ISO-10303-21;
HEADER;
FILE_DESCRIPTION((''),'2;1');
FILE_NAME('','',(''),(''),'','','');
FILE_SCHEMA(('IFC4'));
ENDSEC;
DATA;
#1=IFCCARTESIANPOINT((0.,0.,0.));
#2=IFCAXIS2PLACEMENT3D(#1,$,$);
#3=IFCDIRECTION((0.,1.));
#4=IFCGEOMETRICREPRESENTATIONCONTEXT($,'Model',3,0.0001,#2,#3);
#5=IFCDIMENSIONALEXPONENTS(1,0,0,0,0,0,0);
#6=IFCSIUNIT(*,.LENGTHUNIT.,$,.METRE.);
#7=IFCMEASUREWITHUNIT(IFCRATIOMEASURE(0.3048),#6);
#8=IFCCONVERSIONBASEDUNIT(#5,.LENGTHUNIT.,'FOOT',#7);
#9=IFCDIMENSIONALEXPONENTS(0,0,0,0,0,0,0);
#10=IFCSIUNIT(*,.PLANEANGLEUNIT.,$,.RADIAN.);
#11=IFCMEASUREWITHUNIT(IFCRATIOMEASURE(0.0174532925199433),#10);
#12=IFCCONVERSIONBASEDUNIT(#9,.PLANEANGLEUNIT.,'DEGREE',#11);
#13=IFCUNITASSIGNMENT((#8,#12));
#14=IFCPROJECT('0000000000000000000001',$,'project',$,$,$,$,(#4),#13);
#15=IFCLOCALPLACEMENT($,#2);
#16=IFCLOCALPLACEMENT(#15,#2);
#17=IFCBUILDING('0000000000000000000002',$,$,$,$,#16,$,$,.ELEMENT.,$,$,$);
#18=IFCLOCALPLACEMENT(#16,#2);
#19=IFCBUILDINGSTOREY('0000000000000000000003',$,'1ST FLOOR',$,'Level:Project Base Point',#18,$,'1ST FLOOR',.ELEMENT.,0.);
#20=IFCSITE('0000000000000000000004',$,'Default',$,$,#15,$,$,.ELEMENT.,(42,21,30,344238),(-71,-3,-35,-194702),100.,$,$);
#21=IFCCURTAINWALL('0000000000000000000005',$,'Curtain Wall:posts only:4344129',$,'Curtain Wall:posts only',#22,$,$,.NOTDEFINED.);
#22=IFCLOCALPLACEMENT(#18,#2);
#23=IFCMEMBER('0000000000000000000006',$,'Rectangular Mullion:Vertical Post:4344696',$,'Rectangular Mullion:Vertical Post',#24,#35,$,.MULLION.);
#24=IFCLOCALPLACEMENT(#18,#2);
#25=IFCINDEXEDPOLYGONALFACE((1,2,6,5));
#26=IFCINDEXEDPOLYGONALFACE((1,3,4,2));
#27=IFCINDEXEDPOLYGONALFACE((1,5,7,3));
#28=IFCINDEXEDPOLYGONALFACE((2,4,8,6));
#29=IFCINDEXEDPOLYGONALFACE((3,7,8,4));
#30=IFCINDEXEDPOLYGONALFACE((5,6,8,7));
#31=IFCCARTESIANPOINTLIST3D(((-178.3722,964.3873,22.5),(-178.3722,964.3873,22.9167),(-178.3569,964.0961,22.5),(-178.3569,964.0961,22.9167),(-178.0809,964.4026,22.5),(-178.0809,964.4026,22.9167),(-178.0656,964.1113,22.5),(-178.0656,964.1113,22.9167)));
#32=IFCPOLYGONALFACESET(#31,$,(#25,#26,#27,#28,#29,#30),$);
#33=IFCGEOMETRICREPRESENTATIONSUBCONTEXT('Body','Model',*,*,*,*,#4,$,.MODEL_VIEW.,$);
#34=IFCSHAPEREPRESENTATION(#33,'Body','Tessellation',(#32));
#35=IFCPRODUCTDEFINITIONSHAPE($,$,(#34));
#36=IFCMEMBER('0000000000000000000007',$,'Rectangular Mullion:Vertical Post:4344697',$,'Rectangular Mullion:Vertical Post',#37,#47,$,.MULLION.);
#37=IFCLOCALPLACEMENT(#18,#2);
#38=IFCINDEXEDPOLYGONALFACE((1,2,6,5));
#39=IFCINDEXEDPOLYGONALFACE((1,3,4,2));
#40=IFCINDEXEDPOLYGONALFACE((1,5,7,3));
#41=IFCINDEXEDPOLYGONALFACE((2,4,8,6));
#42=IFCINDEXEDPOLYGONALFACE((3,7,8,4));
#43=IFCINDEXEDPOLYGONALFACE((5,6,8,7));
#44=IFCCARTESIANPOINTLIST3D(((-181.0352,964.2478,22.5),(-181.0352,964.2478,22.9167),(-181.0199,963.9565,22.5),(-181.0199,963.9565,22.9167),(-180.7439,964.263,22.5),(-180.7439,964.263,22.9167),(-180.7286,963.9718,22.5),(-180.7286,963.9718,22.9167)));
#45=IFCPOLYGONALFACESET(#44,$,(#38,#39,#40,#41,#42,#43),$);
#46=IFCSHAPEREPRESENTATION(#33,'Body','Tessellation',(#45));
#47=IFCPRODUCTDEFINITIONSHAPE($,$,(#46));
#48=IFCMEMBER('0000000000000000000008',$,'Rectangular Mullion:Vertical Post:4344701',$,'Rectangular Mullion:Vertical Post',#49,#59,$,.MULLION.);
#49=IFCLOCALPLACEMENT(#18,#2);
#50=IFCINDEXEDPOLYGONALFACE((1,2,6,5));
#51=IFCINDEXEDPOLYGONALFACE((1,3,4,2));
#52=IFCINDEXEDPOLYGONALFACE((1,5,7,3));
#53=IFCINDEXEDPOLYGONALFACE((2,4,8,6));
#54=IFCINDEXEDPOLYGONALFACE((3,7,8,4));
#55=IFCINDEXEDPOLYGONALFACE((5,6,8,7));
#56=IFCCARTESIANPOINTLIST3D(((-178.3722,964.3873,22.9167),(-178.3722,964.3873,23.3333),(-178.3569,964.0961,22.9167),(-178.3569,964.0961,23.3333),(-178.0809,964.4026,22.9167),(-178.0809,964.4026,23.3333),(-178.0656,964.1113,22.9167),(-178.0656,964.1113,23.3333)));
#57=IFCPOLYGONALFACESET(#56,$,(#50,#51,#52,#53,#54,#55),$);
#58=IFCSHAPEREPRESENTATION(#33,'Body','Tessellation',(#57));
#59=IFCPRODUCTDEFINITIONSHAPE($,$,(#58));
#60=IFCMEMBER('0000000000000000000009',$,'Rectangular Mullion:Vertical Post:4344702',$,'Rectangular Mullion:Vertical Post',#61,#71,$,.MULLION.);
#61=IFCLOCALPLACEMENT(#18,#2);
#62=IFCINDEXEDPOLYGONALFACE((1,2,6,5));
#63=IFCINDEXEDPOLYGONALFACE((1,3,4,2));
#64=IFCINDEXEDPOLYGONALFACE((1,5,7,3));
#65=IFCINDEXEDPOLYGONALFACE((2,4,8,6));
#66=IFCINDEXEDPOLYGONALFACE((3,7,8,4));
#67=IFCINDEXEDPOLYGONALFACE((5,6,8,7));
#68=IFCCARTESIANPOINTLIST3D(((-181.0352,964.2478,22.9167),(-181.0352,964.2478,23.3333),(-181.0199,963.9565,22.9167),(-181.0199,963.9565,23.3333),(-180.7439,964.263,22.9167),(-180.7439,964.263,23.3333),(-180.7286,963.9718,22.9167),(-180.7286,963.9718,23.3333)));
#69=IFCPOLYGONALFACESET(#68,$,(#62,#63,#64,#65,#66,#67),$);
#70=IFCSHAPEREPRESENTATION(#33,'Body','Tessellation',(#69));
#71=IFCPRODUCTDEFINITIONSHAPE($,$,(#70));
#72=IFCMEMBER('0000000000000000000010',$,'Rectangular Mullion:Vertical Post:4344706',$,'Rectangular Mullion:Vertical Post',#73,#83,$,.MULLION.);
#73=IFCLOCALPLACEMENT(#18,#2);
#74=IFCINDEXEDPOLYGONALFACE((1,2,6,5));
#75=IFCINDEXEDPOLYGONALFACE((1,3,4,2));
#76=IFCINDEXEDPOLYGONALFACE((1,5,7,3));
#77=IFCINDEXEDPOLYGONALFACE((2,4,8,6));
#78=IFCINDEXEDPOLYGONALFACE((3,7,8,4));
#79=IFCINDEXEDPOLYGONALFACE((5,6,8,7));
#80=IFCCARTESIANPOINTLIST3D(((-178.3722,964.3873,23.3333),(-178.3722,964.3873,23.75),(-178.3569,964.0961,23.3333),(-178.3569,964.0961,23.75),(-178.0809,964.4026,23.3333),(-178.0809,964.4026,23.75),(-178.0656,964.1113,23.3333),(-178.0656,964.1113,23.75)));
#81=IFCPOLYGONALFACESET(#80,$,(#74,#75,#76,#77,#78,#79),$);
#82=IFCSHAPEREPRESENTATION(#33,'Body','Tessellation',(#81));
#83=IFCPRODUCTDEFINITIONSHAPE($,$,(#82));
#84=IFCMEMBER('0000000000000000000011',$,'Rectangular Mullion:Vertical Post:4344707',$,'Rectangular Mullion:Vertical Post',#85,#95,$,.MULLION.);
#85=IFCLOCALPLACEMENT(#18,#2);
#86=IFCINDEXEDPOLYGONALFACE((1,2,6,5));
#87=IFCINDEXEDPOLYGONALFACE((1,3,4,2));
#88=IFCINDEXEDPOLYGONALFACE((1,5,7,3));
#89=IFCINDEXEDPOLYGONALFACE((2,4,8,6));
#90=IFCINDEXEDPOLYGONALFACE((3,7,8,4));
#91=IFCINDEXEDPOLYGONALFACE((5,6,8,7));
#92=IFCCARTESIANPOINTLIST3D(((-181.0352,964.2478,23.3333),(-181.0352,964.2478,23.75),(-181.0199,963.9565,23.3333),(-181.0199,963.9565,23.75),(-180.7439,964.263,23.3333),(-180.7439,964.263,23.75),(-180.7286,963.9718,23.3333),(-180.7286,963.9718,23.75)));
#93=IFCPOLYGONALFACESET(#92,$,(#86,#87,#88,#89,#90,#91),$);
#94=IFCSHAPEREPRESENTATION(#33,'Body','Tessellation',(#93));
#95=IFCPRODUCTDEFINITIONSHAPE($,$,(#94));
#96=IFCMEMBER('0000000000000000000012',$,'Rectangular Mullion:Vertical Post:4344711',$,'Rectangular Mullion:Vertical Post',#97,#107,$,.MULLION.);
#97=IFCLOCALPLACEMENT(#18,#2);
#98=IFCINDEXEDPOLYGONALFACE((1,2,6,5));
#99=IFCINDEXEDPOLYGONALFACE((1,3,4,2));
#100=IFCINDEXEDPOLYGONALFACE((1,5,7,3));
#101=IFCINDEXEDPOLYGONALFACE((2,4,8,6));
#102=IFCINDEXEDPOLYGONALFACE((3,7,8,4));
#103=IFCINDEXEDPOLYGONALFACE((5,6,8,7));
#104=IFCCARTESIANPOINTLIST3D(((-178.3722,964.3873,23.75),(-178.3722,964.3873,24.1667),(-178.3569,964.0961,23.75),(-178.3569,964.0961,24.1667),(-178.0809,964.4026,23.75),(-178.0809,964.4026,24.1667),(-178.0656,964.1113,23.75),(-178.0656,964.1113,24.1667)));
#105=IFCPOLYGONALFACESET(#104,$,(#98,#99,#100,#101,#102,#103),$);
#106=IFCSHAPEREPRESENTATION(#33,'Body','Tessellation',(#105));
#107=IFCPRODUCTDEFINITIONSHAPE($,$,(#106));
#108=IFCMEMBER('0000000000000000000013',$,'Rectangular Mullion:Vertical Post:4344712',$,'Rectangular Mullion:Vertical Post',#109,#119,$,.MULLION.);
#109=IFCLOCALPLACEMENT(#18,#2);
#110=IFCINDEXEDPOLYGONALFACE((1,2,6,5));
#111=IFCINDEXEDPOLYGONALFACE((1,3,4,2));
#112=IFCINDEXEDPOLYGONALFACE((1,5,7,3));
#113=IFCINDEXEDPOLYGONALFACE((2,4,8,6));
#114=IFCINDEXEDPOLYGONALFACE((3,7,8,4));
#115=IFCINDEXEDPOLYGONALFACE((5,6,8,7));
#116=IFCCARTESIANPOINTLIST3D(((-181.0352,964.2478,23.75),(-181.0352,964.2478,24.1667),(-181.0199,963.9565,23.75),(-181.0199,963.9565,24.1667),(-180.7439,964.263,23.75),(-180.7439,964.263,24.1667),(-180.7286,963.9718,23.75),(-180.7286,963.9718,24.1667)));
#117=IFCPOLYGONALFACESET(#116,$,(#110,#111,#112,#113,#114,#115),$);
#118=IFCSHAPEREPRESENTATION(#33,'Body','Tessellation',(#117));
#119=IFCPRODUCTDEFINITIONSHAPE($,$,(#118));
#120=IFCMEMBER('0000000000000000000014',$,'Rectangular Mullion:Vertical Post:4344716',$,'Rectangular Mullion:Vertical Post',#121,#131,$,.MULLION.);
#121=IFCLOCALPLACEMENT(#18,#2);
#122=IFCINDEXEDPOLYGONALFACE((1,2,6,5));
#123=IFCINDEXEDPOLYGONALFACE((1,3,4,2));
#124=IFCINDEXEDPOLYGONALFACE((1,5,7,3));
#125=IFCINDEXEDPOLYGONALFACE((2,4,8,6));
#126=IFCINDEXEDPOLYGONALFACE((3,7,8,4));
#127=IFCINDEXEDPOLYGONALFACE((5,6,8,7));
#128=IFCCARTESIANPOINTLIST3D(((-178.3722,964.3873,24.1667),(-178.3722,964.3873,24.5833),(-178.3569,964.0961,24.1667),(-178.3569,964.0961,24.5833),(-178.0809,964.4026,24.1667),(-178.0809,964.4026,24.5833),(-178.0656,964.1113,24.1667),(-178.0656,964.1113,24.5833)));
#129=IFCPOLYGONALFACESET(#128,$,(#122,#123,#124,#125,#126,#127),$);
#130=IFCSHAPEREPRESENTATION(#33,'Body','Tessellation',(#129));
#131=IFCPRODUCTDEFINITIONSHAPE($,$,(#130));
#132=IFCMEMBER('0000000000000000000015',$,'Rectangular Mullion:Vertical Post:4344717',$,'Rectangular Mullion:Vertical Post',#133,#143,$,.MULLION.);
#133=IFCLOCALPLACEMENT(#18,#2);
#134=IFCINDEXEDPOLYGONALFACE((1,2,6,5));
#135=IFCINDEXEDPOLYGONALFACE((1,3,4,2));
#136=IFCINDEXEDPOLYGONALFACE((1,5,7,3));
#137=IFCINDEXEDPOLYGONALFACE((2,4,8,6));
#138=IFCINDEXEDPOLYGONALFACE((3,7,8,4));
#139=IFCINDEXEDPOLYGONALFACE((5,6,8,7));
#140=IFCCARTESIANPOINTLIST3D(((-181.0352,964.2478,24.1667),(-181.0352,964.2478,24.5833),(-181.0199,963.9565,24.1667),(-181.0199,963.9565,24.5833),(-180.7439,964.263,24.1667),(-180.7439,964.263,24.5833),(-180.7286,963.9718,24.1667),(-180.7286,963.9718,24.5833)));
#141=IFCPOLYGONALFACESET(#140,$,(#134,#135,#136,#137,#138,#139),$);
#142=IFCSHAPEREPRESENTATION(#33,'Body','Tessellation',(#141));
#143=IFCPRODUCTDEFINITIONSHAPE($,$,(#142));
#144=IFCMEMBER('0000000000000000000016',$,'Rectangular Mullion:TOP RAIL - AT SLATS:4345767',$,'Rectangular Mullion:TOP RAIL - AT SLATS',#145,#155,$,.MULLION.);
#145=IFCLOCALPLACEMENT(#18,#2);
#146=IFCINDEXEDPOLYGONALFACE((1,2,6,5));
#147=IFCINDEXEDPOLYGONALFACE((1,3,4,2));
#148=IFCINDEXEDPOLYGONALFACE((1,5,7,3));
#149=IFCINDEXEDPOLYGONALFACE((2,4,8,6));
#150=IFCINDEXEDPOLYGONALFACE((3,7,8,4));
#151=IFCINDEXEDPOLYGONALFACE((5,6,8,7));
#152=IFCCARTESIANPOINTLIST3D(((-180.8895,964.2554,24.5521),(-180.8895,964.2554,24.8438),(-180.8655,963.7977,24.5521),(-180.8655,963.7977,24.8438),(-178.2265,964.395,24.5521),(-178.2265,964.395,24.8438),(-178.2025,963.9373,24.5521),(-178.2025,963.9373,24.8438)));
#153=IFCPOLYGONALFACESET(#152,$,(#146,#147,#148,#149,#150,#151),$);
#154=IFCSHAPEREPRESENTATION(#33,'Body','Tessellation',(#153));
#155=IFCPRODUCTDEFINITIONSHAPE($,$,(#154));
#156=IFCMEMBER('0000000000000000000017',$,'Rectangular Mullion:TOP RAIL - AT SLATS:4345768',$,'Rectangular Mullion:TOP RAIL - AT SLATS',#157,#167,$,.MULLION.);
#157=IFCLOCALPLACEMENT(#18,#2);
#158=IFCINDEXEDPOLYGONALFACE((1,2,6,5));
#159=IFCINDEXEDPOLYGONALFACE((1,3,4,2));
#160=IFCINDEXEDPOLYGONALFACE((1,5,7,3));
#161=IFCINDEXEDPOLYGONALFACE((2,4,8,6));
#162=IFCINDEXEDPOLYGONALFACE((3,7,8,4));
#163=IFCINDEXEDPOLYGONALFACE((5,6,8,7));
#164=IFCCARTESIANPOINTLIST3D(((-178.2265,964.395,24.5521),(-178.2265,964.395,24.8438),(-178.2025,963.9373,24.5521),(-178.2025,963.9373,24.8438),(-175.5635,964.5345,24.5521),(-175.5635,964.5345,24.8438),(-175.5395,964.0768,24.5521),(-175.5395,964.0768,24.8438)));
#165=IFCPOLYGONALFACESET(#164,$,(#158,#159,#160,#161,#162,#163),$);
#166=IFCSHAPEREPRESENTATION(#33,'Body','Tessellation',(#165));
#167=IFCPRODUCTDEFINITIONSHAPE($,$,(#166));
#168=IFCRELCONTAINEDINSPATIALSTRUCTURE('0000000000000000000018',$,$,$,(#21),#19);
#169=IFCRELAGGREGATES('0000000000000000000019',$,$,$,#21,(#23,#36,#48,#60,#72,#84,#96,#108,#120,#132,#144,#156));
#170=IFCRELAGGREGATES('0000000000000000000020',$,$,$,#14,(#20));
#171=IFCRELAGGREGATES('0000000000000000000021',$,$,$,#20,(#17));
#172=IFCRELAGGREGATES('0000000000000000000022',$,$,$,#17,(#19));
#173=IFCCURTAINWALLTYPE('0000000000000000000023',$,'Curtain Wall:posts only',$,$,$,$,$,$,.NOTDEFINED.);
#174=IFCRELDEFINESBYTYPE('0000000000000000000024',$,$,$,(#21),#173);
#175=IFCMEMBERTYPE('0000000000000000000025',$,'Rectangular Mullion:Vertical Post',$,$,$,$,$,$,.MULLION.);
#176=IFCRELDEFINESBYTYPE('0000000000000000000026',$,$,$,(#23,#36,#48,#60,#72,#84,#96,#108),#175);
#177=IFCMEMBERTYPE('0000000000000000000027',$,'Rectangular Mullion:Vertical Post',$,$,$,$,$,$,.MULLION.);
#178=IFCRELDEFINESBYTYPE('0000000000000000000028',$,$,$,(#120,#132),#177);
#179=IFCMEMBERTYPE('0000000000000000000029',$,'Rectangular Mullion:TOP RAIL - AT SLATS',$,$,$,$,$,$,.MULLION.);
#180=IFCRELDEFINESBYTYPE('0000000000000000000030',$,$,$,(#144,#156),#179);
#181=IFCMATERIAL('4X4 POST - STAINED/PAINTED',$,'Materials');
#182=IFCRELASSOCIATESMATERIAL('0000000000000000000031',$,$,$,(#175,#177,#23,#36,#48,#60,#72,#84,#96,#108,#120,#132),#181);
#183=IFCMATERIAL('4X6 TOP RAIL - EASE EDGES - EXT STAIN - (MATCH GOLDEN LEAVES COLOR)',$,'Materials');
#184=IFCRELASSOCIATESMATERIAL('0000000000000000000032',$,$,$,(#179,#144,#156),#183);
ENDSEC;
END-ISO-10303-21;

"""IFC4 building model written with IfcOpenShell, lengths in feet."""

from ifc_helpers import new_model, entity, si_unit, converted_unit, direction, frame, origin, origin_2d_with_axis, place, context, subcontext, project, spatial, rectangle, extrude, source, transform, mapped, material, material_profile, profile_set, profile_usage, type_object, type_shapes, element, aggregate, save


model = new_model("IFC4")

# Units and contexts
model_context = context("Model", 3, precision=0.0001, world=origin(), true_north=direction((0.0, 1.0)))
body_context = subcontext(model_context, "Body", "Model", "MODEL_VIEW")
ifc_project = project(units=[converted_unit("LENGTHUNIT", "FOOT", entity("IfcRatioMeasure", 0.3048), si_unit("LENGTHUNIT", "METRE"), dimensions=[1, 0, 0, 0, 0, 0, 0]), converted_unit("PLANEANGLEUNIT", "DEGREE", entity("IfcRatioMeasure", 0.0174532925199433), si_unit("PLANEANGLEUNIT", "RADIAN"), dimensions=[0, 0, 0, 0, 0, 0, 0])], contexts=[model_context])

# Site, building, storey
site_placement = place(None, origin())
site = spatial("IfcSite", under=ifc_project, at=site_placement, Name="Default", CompositionType="ELEMENT", RefLatitude=(42, 21, 30, 344238), RefLongitude=(-71, -3, -35, -194702), RefElevation=100.0)
building_placement = place(site_placement, origin())
building = spatial("IfcBuilding", under=site, at=building_placement, CompositionType="ELEMENT")
storey_placement = place(building_placement, origin())
storey = spatial("IfcBuildingStorey", under=building, at=storey_placement, Name="1ST FLOOR", ObjectType="Level:Project Base Point", LongName="1ST FLOOR", CompositionType="ELEMENT", Elevation=0.0)

# Curtain wall, members
curtain_wall_type_1 = type_object("IfcCurtainWallType", Name="Curtain Wall:posts only", PredefinedType="NOTDEFINED")
curtain_wall_1_placement = place(storey_placement, origin())
curtain_wall_1 = element("IfcCurtainWall", 1, at=curtain_wall_1_placement, inside=storey, type_object=curtain_wall_type_1, Name="Curtain Wall:posts only:4344129", ObjectType="Curtain Wall:posts only", PredefinedType="NOTDEFINED")
ifc_material_1 = material(Name="4X4 POST - STAINED/PAINTED", Category="Materials")
ifc_material_profile_1 = material_profile(ifc_material_1, rectangle(XDim=0.2917, YDim=0.2917, at=origin_2d_with_axis()), Name="Vertical Post")
ifc_profile_set_1 = profile_set([ifc_material_profile_1], Name="Vertical Post")
ifc_profile_usage_1 = profile_usage(ifc_profile_set_1)
member_type_1 = type_object("IfcMemberType", Name="Rectangular Mullion:Vertical Post", PredefinedType="MULLION", material=ifc_profile_set_1)
shared_shape_1 = source(origin(), body_context, "Body", "SweptSolid", [
    extrude(rectangle(XDim=0.2917, YDim=0.2917, at=origin_2d_with_axis()), frame((0.0, -0.2083, -0.4167), z_axis=(0.0, 0.0, 1.0), x_axis=(0.0, -1.0, 0.0)), (0.0, 0.0, 1.0), 0.4167),
])
type_shapes(member_type_1, [shared_shape_1])
member_1_placement = place(storey_placement, frame((-178.2298, 964.4574, 22.5), z_axis=(0.0, 0.0, -1.0), x_axis=(-0.99863, -0.052336, 0.0)))
member_1 = element("IfcMember", 2, at=member_1_placement, type_object=member_type_1, material=ifc_profile_usage_1, Name="Rectangular Mullion:Vertical Post:4344696", ObjectType="Rectangular Mullion:Vertical Post", PredefinedType="MULLION", context=body_context, shape_type="MappedRepresentation", body=[
    mapped(shared_shape_1, transform((0.0, 0.0, 0.0), scale=1.0)),
])
ifc_profile_usage_2 = profile_usage(ifc_profile_set_1)
member_2_placement = place(storey_placement, frame((-180.8928, 964.3178, 22.5), z_axis=(0.0, 0.0, -1.0), x_axis=(-0.99863, -0.052336, 0.0)))
member_2 = element("IfcMember", 3, at=member_2_placement, type_object=member_type_1, material=ifc_profile_usage_2, Name="Rectangular Mullion:Vertical Post:4344697", ObjectType="Rectangular Mullion:Vertical Post", PredefinedType="MULLION", context=body_context, shape_type="MappedRepresentation", body=[
    mapped(shared_shape_1, transform((0.0, 0.0, 0.0), scale=1.0)),
])
ifc_profile_usage_3 = profile_usage(ifc_profile_set_1)
member_3_placement = place(storey_placement, frame((-178.2298, 964.4574, 22.9167), z_axis=(0.0, 0.0, -1.0), x_axis=(-0.99863, -0.052336, 0.0)))
member_3 = element("IfcMember", 4, at=member_3_placement, type_object=member_type_1, material=ifc_profile_usage_3, Name="Rectangular Mullion:Vertical Post:4344701", ObjectType="Rectangular Mullion:Vertical Post", PredefinedType="MULLION", context=body_context, shape_type="MappedRepresentation", body=[
    mapped(shared_shape_1, transform((0.0, 0.0, 0.0), scale=1.0)),
])
ifc_profile_usage_4 = profile_usage(ifc_profile_set_1)
member_4_placement = place(storey_placement, frame((-180.8928, 964.3178, 22.9167), z_axis=(0.0, 0.0, -1.0), x_axis=(-0.99863, -0.052336, 0.0)))
member_4 = element("IfcMember", 5, at=member_4_placement, type_object=member_type_1, material=ifc_profile_usage_4, Name="Rectangular Mullion:Vertical Post:4344702", ObjectType="Rectangular Mullion:Vertical Post", PredefinedType="MULLION", context=body_context, shape_type="MappedRepresentation", body=[
    mapped(shared_shape_1, transform((0.0, 0.0, 0.0), scale=1.0)),
])
ifc_profile_usage_5 = profile_usage(ifc_profile_set_1)
member_5_placement = place(storey_placement, frame((-178.2298, 964.4574, 23.3333), z_axis=(0.0, 0.0, -1.0), x_axis=(-0.99863, -0.052336, 0.0)))
member_5 = element("IfcMember", 6, at=member_5_placement, type_object=member_type_1, material=ifc_profile_usage_5, Name="Rectangular Mullion:Vertical Post:4344706", ObjectType="Rectangular Mullion:Vertical Post", PredefinedType="MULLION", context=body_context, shape_type="MappedRepresentation", body=[
    mapped(shared_shape_1, transform((0.0, 0.0, 0.0), scale=1.0)),
])
ifc_profile_usage_6 = profile_usage(ifc_profile_set_1)
member_6_placement = place(storey_placement, frame((-180.8928, 964.3178, 23.3333), z_axis=(0.0, 0.0, -1.0), x_axis=(-0.99863, -0.052336, 0.0)))
member_6 = element("IfcMember", 7, at=member_6_placement, type_object=member_type_1, material=ifc_profile_usage_6, Name="Rectangular Mullion:Vertical Post:4344707", ObjectType="Rectangular Mullion:Vertical Post", PredefinedType="MULLION", context=body_context, shape_type="MappedRepresentation", body=[
    mapped(shared_shape_1, transform((0.0, 0.0, 0.0), scale=1.0)),
])
ifc_profile_usage_7 = profile_usage(ifc_profile_set_1)
member_7_placement = place(storey_placement, frame((-178.2298, 964.4574, 23.75), z_axis=(0.0, 0.0, -1.0), x_axis=(-0.99863, -0.052336, 0.0)))
member_7 = element("IfcMember", 8, at=member_7_placement, type_object=member_type_1, material=ifc_profile_usage_7, Name="Rectangular Mullion:Vertical Post:4344711", ObjectType="Rectangular Mullion:Vertical Post", PredefinedType="MULLION", context=body_context, shape_type="MappedRepresentation", body=[
    mapped(shared_shape_1, transform((0.0, 0.0, 0.0), scale=1.0)),
])
ifc_profile_usage_8 = profile_usage(ifc_profile_set_1)
member_8_placement = place(storey_placement, frame((-180.8928, 964.3178, 23.75), z_axis=(0.0, 0.0, -1.0), x_axis=(-0.99863, -0.052336, 0.0)))
member_8 = element("IfcMember", 9, at=member_8_placement, type_object=member_type_1, material=ifc_profile_usage_8, Name="Rectangular Mullion:Vertical Post:4344712", ObjectType="Rectangular Mullion:Vertical Post", PredefinedType="MULLION", context=body_context, shape_type="MappedRepresentation", body=[
    mapped(shared_shape_1, transform((0.0, 0.0, 0.0), scale=1.0)),
])
ifc_profile_usage_9 = profile_usage(ifc_profile_set_1)
member_type_2 = type_object("IfcMemberType", Name="Rectangular Mullion:Vertical Post", PredefinedType="MULLION", material=ifc_profile_set_1)
shared_shape_2 = source(origin(), body_context, "Body", "SweptSolid", [
    extrude(rectangle(XDim=0.2917, YDim=0.2917, at=origin_2d_with_axis()), frame((0.0, -0.2083, -0.4167), z_axis=(0.0, 0.0, 1.0), x_axis=(0.0, -1.0, 0.0)), (0.0, 0.0, 1.0), 0.4167),
])
type_shapes(member_type_2, [shared_shape_2])
member_9_placement = place(storey_placement, frame((-178.2298, 964.4574, 24.1667), z_axis=(0.0, 0.0, -1.0), x_axis=(-0.99863, -0.052336, 0.0)))
member_9 = element("IfcMember", 10, at=member_9_placement, type_object=member_type_2, material=ifc_profile_usage_9, Name="Rectangular Mullion:Vertical Post:4344716", ObjectType="Rectangular Mullion:Vertical Post", PredefinedType="MULLION", context=body_context, shape_type="MappedRepresentation", body=[
    mapped(shared_shape_2, transform((0.0, 0.0, 0.0), scale=1.0)),
])
ifc_profile_usage_10 = profile_usage(ifc_profile_set_1)
member_10_placement = place(storey_placement, frame((-180.8928, 964.3178, 24.1667), z_axis=(0.0, 0.0, -1.0), x_axis=(-0.99863, -0.052336, 0.0)))
member_10 = element("IfcMember", 11, at=member_10_placement, type_object=member_type_2, material=ifc_profile_usage_10, Name="Rectangular Mullion:Vertical Post:4344717", ObjectType="Rectangular Mullion:Vertical Post", PredefinedType="MULLION", context=body_context, shape_type="MappedRepresentation", body=[
    mapped(shared_shape_2, transform((0.0, 0.0, 0.0), scale=1.0)),
])
ifc_material_2 = material(Name="4X6 TOP RAIL - EASE EDGES - EXT STAIN - (MATCH GOLDEN LEAVES COLOR)", Category="Materials")
ifc_material_profile_2 = material_profile(ifc_material_2, rectangle(XDim=0.4583, YDim=0.2917, at=origin_2d_with_axis()), Name="TOP RAIL - AT SLATS")
ifc_profile_set_2 = profile_set([ifc_material_profile_2], Name="TOP RAIL - AT SLATS")
ifc_profile_usage_11 = profile_usage(ifc_profile_set_2)
member_type_3 = type_object("IfcMemberType", Name="Rectangular Mullion:TOP RAIL - AT SLATS", PredefinedType="MULLION", material=ifc_profile_set_2)
shared_shape_3 = source(origin(), body_context, "Body", "SweptSolid", [
    extrude(rectangle(XDim=0.4583, YDim=0.2917, at=origin_2d_with_axis()), frame((-0.1458, -0.2917, -2.6667), z_axis=(0.0, 0.0, 1.0), x_axis=(0.0, -1.0, 0.0)), (0.0, 0.0, 1.0), 2.6667),
])
type_shapes(member_type_3, [shared_shape_3])
member_11_placement = place(storey_placement, frame((-180.8928, 964.3178, 24.8438), z_axis=(-0.99863, -0.052336, 0.0), x_axis=(0.0, 0.0, 1.0)))
member_11 = element("IfcMember", 12, at=member_11_placement, type_object=member_type_3, material=ifc_profile_usage_11, Name="Rectangular Mullion:TOP RAIL - AT SLATS:4345767", ObjectType="Rectangular Mullion:TOP RAIL - AT SLATS", PredefinedType="MULLION", context=body_context, shape_type="MappedRepresentation", body=[
    mapped(shared_shape_3, transform((0.0, 0.0, 0.0), scale=1.0)),
])
ifc_profile_usage_12 = profile_usage(ifc_profile_set_2)
member_12_placement = place(storey_placement, frame((-178.2298, 964.4574, 24.8438), z_axis=(-0.99863, -0.052336, 0.0), x_axis=(0.0, 0.0, 1.0)))
member_12 = element("IfcMember", 13, at=member_12_placement, type_object=member_type_3, material=ifc_profile_usage_12, Name="Rectangular Mullion:TOP RAIL - AT SLATS:4345768", ObjectType="Rectangular Mullion:TOP RAIL - AT SLATS", PredefinedType="MULLION", context=body_context, shape_type="MappedRepresentation", body=[
    mapped(shared_shape_3, transform((0.0, 0.0, 0.0), scale=1.0)),
])
aggregate(curtain_wall_1, [member_1, member_2, member_3, member_4, member_5, member_6, member_7, member_8, member_9, member_10, member_11, member_12])

save(model, "model.ifc")
